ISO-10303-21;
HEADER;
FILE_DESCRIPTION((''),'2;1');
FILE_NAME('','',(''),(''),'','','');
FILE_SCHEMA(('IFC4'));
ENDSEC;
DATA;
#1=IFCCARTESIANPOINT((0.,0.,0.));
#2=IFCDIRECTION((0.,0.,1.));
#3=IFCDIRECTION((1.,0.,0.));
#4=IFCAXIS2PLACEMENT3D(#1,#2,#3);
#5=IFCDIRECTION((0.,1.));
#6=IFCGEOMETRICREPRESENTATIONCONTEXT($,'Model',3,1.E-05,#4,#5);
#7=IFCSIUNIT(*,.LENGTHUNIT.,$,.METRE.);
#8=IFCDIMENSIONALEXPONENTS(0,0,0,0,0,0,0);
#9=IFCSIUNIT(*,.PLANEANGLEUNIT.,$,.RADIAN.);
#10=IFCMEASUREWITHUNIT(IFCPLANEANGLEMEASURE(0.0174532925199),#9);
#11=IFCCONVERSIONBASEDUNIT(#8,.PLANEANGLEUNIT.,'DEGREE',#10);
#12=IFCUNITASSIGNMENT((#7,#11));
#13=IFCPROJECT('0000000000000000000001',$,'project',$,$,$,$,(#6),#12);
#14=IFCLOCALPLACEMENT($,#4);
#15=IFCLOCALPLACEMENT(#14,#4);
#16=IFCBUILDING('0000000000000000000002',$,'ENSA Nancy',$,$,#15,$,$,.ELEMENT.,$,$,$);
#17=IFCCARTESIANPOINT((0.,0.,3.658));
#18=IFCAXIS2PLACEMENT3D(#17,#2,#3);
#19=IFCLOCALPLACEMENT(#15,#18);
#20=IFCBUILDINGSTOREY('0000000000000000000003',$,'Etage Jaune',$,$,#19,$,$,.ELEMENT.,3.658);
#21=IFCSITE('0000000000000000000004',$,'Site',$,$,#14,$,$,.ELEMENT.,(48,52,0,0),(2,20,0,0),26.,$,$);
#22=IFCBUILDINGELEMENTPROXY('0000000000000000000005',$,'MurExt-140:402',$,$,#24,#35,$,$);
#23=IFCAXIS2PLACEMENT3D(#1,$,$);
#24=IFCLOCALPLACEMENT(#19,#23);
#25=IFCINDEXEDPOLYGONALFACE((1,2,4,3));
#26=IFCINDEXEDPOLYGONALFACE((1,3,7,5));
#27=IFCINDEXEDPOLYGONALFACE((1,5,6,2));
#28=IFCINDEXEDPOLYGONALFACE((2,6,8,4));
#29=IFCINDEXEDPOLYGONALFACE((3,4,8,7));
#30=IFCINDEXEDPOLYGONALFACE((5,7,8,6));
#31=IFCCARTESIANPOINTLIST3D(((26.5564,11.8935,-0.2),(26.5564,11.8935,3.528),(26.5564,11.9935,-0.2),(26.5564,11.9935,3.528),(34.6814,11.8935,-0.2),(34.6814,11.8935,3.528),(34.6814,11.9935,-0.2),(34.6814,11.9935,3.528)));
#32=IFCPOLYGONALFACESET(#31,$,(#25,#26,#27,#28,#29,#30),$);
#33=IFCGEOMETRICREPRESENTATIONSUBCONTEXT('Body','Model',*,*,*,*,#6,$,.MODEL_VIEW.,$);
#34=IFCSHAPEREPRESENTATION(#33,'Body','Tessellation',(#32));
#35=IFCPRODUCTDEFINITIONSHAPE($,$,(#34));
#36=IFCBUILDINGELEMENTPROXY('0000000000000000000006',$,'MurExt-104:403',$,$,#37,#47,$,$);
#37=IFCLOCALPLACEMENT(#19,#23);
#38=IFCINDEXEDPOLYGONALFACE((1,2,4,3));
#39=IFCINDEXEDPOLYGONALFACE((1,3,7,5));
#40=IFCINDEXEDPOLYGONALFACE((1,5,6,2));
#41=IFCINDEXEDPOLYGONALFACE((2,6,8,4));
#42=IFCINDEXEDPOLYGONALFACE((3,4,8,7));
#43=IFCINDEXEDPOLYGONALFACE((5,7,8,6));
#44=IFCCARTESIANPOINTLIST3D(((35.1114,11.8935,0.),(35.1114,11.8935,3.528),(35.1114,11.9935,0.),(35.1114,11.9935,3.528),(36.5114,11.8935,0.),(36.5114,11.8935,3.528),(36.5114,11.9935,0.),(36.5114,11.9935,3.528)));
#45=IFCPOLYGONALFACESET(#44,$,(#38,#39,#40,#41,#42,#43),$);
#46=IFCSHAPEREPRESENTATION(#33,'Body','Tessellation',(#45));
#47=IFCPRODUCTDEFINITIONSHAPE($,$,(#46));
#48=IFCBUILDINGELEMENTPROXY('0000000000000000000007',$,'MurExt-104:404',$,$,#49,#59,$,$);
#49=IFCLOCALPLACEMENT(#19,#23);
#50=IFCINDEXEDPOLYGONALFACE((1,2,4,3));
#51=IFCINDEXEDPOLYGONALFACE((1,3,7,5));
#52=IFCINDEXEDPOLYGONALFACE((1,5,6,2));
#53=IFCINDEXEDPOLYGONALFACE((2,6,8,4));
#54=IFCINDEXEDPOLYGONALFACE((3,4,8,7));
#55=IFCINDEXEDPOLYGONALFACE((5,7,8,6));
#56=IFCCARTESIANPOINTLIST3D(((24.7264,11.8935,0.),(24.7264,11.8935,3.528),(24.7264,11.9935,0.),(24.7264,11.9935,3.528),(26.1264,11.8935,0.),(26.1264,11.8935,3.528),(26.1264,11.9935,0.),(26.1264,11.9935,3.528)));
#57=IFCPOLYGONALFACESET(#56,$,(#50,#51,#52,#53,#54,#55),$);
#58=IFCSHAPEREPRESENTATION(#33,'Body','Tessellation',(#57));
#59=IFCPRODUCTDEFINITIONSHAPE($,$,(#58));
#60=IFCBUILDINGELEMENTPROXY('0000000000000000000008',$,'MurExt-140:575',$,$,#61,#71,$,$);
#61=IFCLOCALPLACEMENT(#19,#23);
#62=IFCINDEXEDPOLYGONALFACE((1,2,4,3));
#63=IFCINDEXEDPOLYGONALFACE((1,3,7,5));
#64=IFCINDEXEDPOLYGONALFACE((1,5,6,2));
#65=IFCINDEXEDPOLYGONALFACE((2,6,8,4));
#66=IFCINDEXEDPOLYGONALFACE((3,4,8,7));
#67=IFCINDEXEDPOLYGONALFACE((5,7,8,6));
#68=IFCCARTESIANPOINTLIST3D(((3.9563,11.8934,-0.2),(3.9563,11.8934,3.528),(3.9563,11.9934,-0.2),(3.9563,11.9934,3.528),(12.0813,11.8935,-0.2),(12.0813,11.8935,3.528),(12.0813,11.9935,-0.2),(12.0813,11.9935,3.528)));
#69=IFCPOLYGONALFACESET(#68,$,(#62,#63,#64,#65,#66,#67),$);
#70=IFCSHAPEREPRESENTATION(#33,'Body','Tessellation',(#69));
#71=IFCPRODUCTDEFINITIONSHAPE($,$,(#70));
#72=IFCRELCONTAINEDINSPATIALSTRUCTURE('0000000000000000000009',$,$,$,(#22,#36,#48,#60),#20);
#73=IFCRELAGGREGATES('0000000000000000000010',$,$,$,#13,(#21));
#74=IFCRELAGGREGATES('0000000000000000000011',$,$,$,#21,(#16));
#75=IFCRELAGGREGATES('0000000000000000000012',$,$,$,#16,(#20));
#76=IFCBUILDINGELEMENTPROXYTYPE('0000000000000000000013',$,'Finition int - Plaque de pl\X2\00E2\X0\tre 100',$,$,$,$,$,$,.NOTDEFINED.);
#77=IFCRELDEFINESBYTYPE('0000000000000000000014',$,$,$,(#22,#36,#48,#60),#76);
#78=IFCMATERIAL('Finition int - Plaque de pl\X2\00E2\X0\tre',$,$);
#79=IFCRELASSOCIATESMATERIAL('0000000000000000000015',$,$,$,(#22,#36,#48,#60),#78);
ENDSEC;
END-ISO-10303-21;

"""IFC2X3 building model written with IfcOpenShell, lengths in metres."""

from ifc_helpers import new_model, entity, si_unit, converted_unit, direction, frame, origin_with_axes, place, context, subcontext, project, spatial, polyline, outline, extrude, material, type_object, element, save


model = new_model("IFC2X3")

# Units and contexts
model_context = context("Model", 3, precision=1e-05, world=origin_with_axes(), true_north=direction((0.0, 1.0)))
body_context = subcontext(model_context, "Body", "Model", "MODEL_VIEW")
ifc_project = project(units=[si_unit("LENGTHUNIT", "METRE"), converted_unit("PLANEANGLEUNIT", "DEGREE", entity("IfcPlaneAngleMeasure", 0.0174532925199), si_unit("PLANEANGLEUNIT", "RADIAN"), dimensions=[0, 0, 0, 0, 0, 0, 0])], contexts=[model_context])

# Site, building, storey
site_placement = place(None, origin_with_axes())
site = spatial("IfcSite", under=ifc_project, at=site_placement, Name="Site", CompositionType="ELEMENT", RefLatitude=(48, 52, 0, 0), RefLongitude=(2, 20, 0, 0), RefElevation=26.0)
building_placement = place(site_placement, origin_with_axes())
building = spatial("IfcBuilding", under=site, at=building_placement, Name="ENSA Nancy", CompositionType="ELEMENT")
storey_placement = place(building_placement, frame((0.0, 0.0, 3.658), z_axis=(0.0, 0.0, 1.0), x_axis=(1.0, 0.0, 0.0)))
storey = spatial("IfcBuildingStorey", under=building, at=storey_placement, Name="Etage Jaune", CompositionType="ELEMENT", Elevation=3.658)

# Shared definitions
ifc_material_1 = material(Name="Finition int - Plaque de plâtre")

# Building element proxies
building_element_proxy_type_1 = type_object("IfcBuildingElementProxyType", Name="Finition int - Plaque de plâtre 100", PredefinedType="NOTDEFINED")
proxy_1_placement = place(storey_placement, frame((26.5564, 11.8935, -0.2), z_axis=(0.0, 0.0, 1.0), x_axis=(1.0, 0.0, 0.0)))
element("IfcBuildingElementProxy", 1, at=proxy_1_placement, inside=storey, type_object=building_element_proxy_type_1, material=ifc_material_1, Name="MurExt-140:402", context=body_context, shape_type="SweptSolid", body=[
    extrude(outline(polyline([(0.0, 0.0), (8.125, 0.0), (8.125, 0.1), (0.0, 0.1), (0.0, 0.0)])), origin_with_axes(), (0.0, 0.0, 1.0), 3.728),
])
for number, where, z_axis, x_axis, name in (
    (2, (35.1114, 11.8935, 0.0), (0.0, 0.0, 1.0), (1.0, 0.0, 0.0), "MurExt-104:403"),
    (3, (24.7264, 11.8935, 0.0), (0.0, 0.0, 1.0), (1.0, 0.0, 0.0), "MurExt-104:404"),
):
    element("IfcBuildingElementProxy", number, at=place(storey_placement, frame(where, z_axis=z_axis, x_axis=x_axis)), inside=storey, type_object=building_element_proxy_type_1, material=ifc_material_1, Name=name, context=body_context, shape_type="SweptSolid", body=[
        extrude(outline(polyline([(0.0, 0.0), (1.4, 0.0), (1.4, 0.1), (0.0, 0.1), (0.0, 0.0)])), origin_with_axes(), (0.0, 0.0, 1.0), 3.528),
    ])
proxy_2_placement = place(storey_placement, frame((3.9563, 11.8934, -0.2), z_axis=(0.0, 0.0, 1.0), x_axis=(1.0, 0.000006, 0.0)))
element("IfcBuildingElementProxy", 4, at=proxy_2_placement, inside=storey, type_object=building_element_proxy_type_1, material=ifc_material_1, Name="MurExt-140:575", context=body_context, shape_type="SweptSolid", body=[
    extrude(outline(polyline([(0.0, 0.0), (8.125, 0.0), (8.125, 0.1), (0.0, 0.1), (0.0, 0.0)])), origin_with_axes(), (0.0, 0.0, 1.0), 3.728),
])

save(model, "model.ifc")
